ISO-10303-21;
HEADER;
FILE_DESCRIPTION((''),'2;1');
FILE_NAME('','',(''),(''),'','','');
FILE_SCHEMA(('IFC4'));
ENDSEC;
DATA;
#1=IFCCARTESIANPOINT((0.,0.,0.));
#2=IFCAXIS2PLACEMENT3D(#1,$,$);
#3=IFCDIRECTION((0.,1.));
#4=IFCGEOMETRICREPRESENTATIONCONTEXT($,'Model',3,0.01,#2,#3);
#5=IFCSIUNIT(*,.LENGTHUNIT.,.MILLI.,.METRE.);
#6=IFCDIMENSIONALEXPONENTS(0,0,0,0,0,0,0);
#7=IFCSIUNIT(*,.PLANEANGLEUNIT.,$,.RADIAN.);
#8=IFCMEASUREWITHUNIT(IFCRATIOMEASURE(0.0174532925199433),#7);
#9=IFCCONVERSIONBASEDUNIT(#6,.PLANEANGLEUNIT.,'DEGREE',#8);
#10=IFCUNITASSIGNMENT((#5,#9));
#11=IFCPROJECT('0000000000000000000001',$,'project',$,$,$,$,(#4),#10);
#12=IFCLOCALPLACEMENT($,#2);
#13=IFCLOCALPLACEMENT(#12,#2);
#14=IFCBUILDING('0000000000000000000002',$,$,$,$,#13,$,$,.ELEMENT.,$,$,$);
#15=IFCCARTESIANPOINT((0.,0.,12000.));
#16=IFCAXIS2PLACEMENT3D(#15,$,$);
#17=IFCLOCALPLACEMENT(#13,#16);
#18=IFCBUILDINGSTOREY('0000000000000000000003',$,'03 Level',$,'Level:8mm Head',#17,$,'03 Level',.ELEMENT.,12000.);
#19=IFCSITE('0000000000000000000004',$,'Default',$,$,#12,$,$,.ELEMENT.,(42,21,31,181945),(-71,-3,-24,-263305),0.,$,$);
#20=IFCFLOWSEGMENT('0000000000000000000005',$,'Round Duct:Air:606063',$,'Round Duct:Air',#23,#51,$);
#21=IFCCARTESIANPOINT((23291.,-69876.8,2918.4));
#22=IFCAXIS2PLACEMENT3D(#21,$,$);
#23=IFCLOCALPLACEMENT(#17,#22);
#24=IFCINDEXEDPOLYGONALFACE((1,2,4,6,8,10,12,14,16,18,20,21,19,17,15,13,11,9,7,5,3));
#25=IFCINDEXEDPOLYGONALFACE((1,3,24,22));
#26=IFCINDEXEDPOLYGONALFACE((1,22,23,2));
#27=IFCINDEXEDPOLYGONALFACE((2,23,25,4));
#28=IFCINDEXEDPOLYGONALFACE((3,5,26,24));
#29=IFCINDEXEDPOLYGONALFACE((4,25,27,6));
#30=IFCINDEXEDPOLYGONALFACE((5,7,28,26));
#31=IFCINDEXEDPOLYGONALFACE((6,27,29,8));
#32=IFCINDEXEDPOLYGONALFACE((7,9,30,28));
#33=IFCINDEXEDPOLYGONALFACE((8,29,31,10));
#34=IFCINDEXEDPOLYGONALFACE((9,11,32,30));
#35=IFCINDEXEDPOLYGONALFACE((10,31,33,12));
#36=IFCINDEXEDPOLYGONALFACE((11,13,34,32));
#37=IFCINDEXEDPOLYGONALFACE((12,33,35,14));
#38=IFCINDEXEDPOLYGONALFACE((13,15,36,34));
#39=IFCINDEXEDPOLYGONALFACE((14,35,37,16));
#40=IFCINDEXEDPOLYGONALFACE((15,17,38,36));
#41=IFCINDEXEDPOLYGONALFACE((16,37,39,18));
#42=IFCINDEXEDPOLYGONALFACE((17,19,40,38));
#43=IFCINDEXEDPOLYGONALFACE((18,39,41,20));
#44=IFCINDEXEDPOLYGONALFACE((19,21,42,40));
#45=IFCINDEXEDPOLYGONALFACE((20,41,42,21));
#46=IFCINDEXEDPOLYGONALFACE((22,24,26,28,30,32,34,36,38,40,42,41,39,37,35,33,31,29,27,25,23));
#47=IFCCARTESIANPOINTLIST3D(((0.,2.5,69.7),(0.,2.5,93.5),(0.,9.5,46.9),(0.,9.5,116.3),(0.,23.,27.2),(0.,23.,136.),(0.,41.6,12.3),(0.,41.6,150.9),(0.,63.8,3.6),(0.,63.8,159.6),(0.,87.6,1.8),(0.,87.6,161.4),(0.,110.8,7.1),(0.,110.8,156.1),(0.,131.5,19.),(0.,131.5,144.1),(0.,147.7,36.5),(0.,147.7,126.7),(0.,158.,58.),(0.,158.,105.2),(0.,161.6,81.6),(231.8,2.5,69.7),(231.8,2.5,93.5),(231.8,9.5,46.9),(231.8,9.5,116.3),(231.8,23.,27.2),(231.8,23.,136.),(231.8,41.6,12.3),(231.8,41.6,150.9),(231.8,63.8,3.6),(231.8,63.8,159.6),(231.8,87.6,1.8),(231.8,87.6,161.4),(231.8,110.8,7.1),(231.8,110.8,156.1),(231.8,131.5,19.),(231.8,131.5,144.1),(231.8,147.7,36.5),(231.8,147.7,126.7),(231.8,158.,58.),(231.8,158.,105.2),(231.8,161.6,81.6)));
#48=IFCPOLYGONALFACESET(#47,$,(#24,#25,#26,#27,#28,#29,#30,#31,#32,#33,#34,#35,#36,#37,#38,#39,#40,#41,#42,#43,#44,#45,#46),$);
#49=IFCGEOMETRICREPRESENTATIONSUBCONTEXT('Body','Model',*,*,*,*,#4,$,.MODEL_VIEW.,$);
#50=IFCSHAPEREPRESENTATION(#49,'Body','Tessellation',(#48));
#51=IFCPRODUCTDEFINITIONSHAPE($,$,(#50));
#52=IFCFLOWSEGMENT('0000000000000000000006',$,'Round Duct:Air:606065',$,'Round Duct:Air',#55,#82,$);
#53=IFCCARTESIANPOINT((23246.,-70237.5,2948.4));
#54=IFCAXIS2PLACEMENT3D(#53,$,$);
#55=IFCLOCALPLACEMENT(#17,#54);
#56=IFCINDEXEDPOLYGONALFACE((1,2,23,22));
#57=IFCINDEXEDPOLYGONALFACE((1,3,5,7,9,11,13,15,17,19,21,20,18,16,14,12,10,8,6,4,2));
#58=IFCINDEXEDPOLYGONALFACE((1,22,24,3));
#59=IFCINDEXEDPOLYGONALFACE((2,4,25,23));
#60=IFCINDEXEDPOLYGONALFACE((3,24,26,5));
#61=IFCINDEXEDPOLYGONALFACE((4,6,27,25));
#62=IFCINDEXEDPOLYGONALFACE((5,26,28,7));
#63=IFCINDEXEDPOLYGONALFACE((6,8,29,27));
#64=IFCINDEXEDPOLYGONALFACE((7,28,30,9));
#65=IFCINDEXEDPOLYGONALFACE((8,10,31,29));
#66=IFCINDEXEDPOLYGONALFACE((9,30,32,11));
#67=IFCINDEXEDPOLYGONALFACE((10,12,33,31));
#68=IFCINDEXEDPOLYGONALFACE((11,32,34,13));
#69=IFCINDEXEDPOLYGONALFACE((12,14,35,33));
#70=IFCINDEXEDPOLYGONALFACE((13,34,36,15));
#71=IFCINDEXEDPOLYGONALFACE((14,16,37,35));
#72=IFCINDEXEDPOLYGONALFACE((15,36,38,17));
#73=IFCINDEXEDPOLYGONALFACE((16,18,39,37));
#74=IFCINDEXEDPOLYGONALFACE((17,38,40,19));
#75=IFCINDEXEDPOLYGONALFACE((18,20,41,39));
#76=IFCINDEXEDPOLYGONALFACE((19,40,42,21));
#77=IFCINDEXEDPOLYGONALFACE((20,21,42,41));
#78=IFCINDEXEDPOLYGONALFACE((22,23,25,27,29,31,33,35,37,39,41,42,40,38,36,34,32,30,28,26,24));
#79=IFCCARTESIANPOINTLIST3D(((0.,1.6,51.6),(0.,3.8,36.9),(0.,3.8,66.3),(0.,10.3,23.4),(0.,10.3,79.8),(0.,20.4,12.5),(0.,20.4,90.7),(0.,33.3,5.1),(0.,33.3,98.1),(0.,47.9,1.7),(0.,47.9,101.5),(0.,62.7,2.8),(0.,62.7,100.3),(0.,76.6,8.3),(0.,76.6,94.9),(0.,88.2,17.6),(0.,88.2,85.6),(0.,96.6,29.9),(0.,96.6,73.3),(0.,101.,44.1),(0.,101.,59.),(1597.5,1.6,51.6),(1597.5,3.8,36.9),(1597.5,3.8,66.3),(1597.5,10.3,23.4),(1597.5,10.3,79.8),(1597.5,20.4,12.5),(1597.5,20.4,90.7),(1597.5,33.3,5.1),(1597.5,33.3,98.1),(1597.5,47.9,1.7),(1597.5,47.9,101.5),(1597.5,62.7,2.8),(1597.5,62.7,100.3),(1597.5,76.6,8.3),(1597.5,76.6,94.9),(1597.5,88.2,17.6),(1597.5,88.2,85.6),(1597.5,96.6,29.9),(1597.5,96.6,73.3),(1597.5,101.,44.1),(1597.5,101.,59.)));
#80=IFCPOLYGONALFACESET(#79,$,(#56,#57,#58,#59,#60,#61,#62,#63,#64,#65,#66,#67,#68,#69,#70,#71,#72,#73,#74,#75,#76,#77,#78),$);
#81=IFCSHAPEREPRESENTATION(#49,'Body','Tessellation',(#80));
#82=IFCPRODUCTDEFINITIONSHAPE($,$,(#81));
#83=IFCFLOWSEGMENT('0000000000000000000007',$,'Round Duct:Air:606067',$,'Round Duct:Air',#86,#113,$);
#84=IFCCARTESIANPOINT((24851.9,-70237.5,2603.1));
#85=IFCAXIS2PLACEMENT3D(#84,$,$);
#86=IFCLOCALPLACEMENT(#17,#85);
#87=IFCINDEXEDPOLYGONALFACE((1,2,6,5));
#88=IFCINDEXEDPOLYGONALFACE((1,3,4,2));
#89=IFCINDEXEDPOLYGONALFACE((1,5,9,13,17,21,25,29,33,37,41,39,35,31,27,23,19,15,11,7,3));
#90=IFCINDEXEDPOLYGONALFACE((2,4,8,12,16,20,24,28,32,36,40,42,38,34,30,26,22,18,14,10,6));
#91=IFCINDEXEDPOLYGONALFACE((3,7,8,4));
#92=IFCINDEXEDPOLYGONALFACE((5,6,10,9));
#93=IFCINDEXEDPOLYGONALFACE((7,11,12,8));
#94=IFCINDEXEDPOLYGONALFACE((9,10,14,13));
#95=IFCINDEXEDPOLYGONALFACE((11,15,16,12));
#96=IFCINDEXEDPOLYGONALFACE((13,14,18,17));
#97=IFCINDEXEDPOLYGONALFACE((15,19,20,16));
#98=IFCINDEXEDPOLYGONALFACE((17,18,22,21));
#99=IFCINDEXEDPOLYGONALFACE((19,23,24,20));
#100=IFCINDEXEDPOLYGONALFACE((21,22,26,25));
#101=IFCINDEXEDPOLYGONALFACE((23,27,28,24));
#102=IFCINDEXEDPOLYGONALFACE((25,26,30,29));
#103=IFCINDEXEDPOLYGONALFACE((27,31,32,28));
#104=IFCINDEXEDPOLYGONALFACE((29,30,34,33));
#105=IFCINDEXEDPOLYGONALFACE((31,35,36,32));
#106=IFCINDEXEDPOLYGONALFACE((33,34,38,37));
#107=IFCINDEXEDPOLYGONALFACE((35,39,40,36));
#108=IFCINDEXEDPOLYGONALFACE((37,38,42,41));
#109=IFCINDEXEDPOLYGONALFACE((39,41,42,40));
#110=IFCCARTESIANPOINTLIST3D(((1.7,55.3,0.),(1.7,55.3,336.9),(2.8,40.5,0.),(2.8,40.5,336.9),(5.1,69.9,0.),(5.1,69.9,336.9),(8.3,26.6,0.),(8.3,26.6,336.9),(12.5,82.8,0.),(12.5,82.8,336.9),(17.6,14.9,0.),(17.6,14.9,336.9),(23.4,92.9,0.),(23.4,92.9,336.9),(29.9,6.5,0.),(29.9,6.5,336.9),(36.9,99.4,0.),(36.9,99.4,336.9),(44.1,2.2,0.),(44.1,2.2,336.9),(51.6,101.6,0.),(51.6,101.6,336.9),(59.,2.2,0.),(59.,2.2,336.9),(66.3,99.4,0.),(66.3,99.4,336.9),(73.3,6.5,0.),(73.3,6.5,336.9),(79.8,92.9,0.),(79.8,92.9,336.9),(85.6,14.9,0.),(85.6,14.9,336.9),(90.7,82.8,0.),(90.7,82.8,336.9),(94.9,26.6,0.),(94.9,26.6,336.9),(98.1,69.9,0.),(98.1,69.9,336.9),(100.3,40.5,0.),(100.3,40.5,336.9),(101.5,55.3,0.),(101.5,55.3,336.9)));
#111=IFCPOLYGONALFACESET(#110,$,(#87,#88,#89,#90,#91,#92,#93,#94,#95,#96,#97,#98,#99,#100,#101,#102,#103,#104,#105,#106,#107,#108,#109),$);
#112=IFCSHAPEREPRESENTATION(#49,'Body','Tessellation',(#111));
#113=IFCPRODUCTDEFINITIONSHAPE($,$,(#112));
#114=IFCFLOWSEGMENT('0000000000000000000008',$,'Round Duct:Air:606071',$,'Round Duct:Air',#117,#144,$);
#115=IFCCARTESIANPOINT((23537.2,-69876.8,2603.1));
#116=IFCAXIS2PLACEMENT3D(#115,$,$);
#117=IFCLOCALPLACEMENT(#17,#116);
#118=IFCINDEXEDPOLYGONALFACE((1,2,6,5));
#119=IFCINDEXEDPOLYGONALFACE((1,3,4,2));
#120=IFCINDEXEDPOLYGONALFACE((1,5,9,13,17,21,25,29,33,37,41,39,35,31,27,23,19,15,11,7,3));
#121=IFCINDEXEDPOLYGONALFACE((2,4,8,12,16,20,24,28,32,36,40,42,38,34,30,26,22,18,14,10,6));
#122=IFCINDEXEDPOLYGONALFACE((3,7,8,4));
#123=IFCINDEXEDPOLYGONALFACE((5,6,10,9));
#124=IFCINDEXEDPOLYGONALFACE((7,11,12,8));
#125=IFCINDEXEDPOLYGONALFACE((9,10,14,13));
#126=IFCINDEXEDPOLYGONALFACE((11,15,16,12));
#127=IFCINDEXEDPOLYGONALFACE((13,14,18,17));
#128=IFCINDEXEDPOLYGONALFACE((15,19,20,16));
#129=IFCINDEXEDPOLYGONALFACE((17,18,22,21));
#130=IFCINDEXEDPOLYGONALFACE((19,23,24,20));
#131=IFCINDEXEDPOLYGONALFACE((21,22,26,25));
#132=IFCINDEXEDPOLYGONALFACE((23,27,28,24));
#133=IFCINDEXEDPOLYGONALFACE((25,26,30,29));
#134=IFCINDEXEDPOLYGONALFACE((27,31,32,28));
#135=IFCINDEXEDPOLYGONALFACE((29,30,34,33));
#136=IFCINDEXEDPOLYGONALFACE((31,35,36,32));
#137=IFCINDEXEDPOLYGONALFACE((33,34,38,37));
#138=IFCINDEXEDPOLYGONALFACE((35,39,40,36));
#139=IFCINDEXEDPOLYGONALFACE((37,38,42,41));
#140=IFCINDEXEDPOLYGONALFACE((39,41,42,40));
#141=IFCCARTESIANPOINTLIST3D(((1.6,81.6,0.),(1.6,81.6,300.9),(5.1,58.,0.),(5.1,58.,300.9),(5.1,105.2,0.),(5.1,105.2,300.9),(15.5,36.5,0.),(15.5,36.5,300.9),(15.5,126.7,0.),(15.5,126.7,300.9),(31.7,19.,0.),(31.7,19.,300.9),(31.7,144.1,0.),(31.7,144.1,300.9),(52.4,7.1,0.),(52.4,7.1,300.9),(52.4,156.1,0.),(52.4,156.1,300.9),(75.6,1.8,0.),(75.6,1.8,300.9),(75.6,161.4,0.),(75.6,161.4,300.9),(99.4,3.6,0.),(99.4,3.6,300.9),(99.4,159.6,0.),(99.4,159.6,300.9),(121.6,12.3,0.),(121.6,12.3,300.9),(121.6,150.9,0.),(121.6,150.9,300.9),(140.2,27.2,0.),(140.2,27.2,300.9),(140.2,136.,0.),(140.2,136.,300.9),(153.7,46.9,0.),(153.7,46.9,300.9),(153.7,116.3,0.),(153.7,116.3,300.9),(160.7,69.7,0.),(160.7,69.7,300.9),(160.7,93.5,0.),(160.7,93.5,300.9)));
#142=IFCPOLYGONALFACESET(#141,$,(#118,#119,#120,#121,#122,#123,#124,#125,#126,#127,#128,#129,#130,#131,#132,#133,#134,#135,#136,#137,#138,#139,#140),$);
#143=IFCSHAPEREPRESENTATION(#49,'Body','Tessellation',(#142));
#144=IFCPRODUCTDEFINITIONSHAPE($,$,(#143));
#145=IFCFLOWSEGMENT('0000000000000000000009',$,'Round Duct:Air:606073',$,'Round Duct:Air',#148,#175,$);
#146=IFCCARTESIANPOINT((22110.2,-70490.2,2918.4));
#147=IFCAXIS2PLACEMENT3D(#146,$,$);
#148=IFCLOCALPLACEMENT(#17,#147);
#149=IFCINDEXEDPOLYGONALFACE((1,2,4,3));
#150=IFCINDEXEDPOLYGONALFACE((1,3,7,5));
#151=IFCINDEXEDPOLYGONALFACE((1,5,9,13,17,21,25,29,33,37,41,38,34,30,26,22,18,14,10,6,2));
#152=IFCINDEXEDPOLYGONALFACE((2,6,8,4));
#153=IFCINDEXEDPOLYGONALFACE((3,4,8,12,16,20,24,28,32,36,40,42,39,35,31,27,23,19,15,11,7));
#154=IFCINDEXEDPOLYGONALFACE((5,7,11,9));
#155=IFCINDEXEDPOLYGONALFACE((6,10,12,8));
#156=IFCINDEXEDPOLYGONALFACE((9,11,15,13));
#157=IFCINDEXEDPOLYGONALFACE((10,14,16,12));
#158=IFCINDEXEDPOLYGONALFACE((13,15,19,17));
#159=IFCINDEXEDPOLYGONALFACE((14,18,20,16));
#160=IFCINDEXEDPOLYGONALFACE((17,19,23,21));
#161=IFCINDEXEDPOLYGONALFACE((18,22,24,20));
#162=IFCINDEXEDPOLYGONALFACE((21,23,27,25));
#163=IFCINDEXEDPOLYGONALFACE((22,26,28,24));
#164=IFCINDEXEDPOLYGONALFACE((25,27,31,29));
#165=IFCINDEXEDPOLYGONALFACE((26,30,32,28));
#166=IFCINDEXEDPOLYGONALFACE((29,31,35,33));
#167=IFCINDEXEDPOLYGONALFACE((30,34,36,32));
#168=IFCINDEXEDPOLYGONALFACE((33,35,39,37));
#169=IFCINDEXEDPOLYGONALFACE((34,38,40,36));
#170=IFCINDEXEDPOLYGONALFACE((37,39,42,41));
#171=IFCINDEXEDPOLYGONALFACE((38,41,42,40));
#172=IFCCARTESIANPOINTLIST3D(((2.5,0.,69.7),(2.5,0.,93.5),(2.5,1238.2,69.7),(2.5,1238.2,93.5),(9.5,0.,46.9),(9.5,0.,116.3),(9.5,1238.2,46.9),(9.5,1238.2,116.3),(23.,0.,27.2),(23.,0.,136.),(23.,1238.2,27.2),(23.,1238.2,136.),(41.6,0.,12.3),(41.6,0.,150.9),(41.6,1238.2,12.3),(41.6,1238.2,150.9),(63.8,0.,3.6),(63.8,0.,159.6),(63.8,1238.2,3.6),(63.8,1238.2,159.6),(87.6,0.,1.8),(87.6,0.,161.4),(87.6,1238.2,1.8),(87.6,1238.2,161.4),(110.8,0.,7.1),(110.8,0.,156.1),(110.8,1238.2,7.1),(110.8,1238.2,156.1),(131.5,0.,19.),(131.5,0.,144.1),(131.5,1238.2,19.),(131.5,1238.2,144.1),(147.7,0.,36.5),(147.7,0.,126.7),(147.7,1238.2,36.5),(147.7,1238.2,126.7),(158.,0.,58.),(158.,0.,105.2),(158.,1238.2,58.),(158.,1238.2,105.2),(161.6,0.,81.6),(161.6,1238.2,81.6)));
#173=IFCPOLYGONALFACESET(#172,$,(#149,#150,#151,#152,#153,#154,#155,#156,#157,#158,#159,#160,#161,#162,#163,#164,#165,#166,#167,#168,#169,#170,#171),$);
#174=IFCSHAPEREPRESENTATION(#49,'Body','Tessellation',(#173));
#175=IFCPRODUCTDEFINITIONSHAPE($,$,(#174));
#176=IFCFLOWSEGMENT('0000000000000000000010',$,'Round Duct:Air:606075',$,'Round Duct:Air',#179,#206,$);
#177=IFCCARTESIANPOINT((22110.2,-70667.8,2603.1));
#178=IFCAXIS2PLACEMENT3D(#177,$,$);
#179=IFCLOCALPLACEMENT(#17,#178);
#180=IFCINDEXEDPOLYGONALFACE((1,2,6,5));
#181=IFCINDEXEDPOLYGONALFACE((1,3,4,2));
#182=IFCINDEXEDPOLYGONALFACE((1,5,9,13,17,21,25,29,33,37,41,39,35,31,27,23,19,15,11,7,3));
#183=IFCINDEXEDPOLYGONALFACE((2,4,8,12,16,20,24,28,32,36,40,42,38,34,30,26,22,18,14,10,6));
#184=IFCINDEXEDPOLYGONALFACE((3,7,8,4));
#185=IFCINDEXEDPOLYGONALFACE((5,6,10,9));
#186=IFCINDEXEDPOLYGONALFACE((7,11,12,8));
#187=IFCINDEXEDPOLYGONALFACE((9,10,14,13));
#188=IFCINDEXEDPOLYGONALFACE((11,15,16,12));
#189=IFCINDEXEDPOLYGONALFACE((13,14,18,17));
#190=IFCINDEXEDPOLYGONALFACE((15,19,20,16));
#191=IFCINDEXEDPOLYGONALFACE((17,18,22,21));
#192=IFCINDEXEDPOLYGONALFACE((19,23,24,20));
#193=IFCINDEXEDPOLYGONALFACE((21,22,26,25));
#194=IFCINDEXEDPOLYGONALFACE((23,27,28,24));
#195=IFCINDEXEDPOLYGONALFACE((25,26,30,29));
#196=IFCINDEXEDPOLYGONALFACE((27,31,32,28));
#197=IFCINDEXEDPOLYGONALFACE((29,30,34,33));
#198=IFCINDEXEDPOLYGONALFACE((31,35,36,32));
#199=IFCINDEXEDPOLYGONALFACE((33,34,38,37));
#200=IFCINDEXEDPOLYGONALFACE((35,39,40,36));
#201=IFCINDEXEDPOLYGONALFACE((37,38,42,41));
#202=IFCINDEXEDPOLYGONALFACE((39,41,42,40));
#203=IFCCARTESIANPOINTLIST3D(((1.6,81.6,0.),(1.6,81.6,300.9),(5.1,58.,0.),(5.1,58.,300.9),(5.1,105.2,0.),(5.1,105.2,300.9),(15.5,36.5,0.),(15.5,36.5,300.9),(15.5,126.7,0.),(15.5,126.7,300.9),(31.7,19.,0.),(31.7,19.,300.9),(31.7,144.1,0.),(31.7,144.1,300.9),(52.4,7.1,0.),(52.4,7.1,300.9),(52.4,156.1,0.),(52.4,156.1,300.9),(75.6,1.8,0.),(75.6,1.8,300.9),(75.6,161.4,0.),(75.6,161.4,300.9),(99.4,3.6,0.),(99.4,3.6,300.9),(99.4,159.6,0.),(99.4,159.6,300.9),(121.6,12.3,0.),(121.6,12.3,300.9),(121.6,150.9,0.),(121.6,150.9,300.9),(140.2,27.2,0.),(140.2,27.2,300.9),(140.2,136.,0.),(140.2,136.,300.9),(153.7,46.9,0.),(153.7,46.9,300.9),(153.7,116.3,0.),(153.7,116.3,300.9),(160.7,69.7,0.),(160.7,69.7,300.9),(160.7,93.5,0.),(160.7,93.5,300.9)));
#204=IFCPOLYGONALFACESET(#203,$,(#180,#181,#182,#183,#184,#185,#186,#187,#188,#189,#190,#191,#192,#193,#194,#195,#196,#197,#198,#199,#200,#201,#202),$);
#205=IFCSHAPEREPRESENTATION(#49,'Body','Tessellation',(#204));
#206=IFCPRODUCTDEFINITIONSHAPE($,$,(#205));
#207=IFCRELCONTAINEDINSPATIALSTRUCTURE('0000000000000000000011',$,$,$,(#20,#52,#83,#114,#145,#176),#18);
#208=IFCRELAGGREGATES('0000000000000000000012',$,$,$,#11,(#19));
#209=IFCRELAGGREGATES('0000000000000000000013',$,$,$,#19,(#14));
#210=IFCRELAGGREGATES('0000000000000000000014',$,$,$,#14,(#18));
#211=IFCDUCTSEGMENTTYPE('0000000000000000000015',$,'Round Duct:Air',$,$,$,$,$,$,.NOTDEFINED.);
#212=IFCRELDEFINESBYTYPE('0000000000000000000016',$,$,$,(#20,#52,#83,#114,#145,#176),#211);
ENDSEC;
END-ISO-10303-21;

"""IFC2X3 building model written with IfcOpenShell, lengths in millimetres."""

from ifc_helpers import new_model, entity, si_unit, converted_unit, direction, frame, origin, origin_2d_with_axis, place, context, subcontext, project, spatial, circle, extrude, type_object, element, save


model = new_model("IFC2X3")

# Units and contexts
model_context = context("Model", 3, precision=0.01, world=origin(), true_north=direction((0.0, 1.0)))
body_context = subcontext(model_context, "Body", "Model", "MODEL_VIEW")
ifc_project = project(units=[si_unit("LENGTHUNIT", "METRE", prefix="MILLI"), converted_unit("PLANEANGLEUNIT", "DEGREE", entity("IfcRatioMeasure", 0.0174532925199433), si_unit("PLANEANGLEUNIT", "RADIAN"), dimensions=[0, 0, 0, 0, 0, 0, 0])], contexts=[model_context])

# Site, building, storey
site_placement = place(None, origin())
site = spatial("IfcSite", under=ifc_project, at=site_placement, Name="Default", CompositionType="ELEMENT", RefLatitude=(42, 21, 31, 181945), RefLongitude=(-71, -3, -24, -263305), RefElevation=0.0)
building_placement = place(site_placement, origin())
building = spatial("IfcBuilding", under=site, at=building_placement, CompositionType="ELEMENT")
storey_placement = place(building_placement, frame((0.0, 0.0, 12000.0)))
storey = spatial("IfcBuildingStorey", under=building, at=storey_placement, Name="03 Level", ObjectType="Level:8mm Head", LongName="03 Level", CompositionType="ELEMENT", Elevation=12000.0)

# Flow segments
duct_segment_type_1 = type_object("IfcDuctSegmentType", Name="Round Duct:Air", PredefinedType="NOTDEFINED")
flow_segment_1_placement = place(storey_placement, frame((23291.0, -69876.8, 2918.4)))
element("IfcFlowSegment", 1, at=flow_segment_1_placement, inside=storey, type_object=duct_segment_type_1, Name="Round Duct:Air:606063", ObjectType="Round Duct:Air", context=body_context, shape_type="SweptSolid", body=[
    extrude(circle(Radius=80.0, at=origin_2d_with_axis()), frame((0.0, 81.6, 81.6), z_axis=(1.0, 0.0, 0.0), x_axis=(0.0, 1.0, 0.0)), (0.0, 0.0, 1.0), 231.8),
])
flow_segment_2_placement = place(storey_placement, frame((23246.0, -70237.5, 2948.4)))
element("IfcFlowSegment", 2, at=flow_segment_2_placement, inside=storey, type_object=duct_segment_type_1, Name="Round Duct:Air:606065", ObjectType="Round Duct:Air", context=body_context, shape_type="SweptSolid", body=[
    extrude(circle(Radius=50.0, at=origin_2d_with_axis()), frame((0.0, 51.6, 51.6), z_axis=(1.0, 0.0, 0.0), x_axis=(0.0, -1.0, 0.0)), (0.0, 0.0, 1.0), 1597.5),
])
flow_segment_3_placement = place(storey_placement, frame((24851.9, -70237.5, 2603.1)))
element("IfcFlowSegment", 3, at=flow_segment_3_placement, inside=storey, type_object=duct_segment_type_1, Name="Round Duct:Air:606067", ObjectType="Round Duct:Air", context=body_context, shape_type="SweptSolid", body=[
    extrude(circle(Radius=50.0, at=origin_2d_with_axis()), frame((51.6, 51.6, 0.0), z_axis=(0.0, 0.0, 1.0), x_axis=(0.0, 1.0, 0.0)), (0.0, 0.0, 1.0), 336.9),
])
flow_segment_4_placement = place(storey_placement, frame((23537.2, -69876.8, 2603.1)))
element("IfcFlowSegment", 4, at=flow_segment_4_placement, inside=storey, type_object=duct_segment_type_1, Name="Round Duct:Air:606071", ObjectType="Round Duct:Air", context=body_context, shape_type="SweptSolid", body=[
    extrude(circle(Radius=80.0, at=origin_2d_with_axis()), frame((81.6, 81.6, 0.0), z_axis=(0.0, 0.0, 1.0), x_axis=(-1.0, 0.0, 0.0)), (0.0, 0.0, 1.0), 300.9),
])
flow_segment_5_placement = place(storey_placement, frame((22110.2, -70490.2, 2918.4)))
element("IfcFlowSegment", 5, at=flow_segment_5_placement, inside=storey, type_object=duct_segment_type_1, Name="Round Duct:Air:606073", ObjectType="Round Duct:Air", context=body_context, shape_type="SweptSolid", body=[
    extrude(circle(Radius=80.0, at=origin_2d_with_axis()), frame((81.6, 0.0, 81.6), z_axis=(0.0, 1.0, 0.0), x_axis=(1.0, 0.0, 0.0)), (0.0, 0.0, 1.0), 1238.2),
])
flow_segment_6_placement = place(storey_placement, frame((22110.2, -70667.8, 2603.1)))
element("IfcFlowSegment", 6, at=flow_segment_6_placement, inside=storey, type_object=duct_segment_type_1, Name="Round Duct:Air:606075", ObjectType="Round Duct:Air", context=body_context, shape_type="SweptSolid", body=[
    extrude(circle(Radius=80.0, at=origin_2d_with_axis()), frame((81.6, 81.6, 0.0), z_axis=(0.0, 0.0, 1.0), x_axis=(-1.0, 0.0, 0.0)), (0.0, 0.0, 1.0), 300.9),
])

save(model, "model.ifc")
